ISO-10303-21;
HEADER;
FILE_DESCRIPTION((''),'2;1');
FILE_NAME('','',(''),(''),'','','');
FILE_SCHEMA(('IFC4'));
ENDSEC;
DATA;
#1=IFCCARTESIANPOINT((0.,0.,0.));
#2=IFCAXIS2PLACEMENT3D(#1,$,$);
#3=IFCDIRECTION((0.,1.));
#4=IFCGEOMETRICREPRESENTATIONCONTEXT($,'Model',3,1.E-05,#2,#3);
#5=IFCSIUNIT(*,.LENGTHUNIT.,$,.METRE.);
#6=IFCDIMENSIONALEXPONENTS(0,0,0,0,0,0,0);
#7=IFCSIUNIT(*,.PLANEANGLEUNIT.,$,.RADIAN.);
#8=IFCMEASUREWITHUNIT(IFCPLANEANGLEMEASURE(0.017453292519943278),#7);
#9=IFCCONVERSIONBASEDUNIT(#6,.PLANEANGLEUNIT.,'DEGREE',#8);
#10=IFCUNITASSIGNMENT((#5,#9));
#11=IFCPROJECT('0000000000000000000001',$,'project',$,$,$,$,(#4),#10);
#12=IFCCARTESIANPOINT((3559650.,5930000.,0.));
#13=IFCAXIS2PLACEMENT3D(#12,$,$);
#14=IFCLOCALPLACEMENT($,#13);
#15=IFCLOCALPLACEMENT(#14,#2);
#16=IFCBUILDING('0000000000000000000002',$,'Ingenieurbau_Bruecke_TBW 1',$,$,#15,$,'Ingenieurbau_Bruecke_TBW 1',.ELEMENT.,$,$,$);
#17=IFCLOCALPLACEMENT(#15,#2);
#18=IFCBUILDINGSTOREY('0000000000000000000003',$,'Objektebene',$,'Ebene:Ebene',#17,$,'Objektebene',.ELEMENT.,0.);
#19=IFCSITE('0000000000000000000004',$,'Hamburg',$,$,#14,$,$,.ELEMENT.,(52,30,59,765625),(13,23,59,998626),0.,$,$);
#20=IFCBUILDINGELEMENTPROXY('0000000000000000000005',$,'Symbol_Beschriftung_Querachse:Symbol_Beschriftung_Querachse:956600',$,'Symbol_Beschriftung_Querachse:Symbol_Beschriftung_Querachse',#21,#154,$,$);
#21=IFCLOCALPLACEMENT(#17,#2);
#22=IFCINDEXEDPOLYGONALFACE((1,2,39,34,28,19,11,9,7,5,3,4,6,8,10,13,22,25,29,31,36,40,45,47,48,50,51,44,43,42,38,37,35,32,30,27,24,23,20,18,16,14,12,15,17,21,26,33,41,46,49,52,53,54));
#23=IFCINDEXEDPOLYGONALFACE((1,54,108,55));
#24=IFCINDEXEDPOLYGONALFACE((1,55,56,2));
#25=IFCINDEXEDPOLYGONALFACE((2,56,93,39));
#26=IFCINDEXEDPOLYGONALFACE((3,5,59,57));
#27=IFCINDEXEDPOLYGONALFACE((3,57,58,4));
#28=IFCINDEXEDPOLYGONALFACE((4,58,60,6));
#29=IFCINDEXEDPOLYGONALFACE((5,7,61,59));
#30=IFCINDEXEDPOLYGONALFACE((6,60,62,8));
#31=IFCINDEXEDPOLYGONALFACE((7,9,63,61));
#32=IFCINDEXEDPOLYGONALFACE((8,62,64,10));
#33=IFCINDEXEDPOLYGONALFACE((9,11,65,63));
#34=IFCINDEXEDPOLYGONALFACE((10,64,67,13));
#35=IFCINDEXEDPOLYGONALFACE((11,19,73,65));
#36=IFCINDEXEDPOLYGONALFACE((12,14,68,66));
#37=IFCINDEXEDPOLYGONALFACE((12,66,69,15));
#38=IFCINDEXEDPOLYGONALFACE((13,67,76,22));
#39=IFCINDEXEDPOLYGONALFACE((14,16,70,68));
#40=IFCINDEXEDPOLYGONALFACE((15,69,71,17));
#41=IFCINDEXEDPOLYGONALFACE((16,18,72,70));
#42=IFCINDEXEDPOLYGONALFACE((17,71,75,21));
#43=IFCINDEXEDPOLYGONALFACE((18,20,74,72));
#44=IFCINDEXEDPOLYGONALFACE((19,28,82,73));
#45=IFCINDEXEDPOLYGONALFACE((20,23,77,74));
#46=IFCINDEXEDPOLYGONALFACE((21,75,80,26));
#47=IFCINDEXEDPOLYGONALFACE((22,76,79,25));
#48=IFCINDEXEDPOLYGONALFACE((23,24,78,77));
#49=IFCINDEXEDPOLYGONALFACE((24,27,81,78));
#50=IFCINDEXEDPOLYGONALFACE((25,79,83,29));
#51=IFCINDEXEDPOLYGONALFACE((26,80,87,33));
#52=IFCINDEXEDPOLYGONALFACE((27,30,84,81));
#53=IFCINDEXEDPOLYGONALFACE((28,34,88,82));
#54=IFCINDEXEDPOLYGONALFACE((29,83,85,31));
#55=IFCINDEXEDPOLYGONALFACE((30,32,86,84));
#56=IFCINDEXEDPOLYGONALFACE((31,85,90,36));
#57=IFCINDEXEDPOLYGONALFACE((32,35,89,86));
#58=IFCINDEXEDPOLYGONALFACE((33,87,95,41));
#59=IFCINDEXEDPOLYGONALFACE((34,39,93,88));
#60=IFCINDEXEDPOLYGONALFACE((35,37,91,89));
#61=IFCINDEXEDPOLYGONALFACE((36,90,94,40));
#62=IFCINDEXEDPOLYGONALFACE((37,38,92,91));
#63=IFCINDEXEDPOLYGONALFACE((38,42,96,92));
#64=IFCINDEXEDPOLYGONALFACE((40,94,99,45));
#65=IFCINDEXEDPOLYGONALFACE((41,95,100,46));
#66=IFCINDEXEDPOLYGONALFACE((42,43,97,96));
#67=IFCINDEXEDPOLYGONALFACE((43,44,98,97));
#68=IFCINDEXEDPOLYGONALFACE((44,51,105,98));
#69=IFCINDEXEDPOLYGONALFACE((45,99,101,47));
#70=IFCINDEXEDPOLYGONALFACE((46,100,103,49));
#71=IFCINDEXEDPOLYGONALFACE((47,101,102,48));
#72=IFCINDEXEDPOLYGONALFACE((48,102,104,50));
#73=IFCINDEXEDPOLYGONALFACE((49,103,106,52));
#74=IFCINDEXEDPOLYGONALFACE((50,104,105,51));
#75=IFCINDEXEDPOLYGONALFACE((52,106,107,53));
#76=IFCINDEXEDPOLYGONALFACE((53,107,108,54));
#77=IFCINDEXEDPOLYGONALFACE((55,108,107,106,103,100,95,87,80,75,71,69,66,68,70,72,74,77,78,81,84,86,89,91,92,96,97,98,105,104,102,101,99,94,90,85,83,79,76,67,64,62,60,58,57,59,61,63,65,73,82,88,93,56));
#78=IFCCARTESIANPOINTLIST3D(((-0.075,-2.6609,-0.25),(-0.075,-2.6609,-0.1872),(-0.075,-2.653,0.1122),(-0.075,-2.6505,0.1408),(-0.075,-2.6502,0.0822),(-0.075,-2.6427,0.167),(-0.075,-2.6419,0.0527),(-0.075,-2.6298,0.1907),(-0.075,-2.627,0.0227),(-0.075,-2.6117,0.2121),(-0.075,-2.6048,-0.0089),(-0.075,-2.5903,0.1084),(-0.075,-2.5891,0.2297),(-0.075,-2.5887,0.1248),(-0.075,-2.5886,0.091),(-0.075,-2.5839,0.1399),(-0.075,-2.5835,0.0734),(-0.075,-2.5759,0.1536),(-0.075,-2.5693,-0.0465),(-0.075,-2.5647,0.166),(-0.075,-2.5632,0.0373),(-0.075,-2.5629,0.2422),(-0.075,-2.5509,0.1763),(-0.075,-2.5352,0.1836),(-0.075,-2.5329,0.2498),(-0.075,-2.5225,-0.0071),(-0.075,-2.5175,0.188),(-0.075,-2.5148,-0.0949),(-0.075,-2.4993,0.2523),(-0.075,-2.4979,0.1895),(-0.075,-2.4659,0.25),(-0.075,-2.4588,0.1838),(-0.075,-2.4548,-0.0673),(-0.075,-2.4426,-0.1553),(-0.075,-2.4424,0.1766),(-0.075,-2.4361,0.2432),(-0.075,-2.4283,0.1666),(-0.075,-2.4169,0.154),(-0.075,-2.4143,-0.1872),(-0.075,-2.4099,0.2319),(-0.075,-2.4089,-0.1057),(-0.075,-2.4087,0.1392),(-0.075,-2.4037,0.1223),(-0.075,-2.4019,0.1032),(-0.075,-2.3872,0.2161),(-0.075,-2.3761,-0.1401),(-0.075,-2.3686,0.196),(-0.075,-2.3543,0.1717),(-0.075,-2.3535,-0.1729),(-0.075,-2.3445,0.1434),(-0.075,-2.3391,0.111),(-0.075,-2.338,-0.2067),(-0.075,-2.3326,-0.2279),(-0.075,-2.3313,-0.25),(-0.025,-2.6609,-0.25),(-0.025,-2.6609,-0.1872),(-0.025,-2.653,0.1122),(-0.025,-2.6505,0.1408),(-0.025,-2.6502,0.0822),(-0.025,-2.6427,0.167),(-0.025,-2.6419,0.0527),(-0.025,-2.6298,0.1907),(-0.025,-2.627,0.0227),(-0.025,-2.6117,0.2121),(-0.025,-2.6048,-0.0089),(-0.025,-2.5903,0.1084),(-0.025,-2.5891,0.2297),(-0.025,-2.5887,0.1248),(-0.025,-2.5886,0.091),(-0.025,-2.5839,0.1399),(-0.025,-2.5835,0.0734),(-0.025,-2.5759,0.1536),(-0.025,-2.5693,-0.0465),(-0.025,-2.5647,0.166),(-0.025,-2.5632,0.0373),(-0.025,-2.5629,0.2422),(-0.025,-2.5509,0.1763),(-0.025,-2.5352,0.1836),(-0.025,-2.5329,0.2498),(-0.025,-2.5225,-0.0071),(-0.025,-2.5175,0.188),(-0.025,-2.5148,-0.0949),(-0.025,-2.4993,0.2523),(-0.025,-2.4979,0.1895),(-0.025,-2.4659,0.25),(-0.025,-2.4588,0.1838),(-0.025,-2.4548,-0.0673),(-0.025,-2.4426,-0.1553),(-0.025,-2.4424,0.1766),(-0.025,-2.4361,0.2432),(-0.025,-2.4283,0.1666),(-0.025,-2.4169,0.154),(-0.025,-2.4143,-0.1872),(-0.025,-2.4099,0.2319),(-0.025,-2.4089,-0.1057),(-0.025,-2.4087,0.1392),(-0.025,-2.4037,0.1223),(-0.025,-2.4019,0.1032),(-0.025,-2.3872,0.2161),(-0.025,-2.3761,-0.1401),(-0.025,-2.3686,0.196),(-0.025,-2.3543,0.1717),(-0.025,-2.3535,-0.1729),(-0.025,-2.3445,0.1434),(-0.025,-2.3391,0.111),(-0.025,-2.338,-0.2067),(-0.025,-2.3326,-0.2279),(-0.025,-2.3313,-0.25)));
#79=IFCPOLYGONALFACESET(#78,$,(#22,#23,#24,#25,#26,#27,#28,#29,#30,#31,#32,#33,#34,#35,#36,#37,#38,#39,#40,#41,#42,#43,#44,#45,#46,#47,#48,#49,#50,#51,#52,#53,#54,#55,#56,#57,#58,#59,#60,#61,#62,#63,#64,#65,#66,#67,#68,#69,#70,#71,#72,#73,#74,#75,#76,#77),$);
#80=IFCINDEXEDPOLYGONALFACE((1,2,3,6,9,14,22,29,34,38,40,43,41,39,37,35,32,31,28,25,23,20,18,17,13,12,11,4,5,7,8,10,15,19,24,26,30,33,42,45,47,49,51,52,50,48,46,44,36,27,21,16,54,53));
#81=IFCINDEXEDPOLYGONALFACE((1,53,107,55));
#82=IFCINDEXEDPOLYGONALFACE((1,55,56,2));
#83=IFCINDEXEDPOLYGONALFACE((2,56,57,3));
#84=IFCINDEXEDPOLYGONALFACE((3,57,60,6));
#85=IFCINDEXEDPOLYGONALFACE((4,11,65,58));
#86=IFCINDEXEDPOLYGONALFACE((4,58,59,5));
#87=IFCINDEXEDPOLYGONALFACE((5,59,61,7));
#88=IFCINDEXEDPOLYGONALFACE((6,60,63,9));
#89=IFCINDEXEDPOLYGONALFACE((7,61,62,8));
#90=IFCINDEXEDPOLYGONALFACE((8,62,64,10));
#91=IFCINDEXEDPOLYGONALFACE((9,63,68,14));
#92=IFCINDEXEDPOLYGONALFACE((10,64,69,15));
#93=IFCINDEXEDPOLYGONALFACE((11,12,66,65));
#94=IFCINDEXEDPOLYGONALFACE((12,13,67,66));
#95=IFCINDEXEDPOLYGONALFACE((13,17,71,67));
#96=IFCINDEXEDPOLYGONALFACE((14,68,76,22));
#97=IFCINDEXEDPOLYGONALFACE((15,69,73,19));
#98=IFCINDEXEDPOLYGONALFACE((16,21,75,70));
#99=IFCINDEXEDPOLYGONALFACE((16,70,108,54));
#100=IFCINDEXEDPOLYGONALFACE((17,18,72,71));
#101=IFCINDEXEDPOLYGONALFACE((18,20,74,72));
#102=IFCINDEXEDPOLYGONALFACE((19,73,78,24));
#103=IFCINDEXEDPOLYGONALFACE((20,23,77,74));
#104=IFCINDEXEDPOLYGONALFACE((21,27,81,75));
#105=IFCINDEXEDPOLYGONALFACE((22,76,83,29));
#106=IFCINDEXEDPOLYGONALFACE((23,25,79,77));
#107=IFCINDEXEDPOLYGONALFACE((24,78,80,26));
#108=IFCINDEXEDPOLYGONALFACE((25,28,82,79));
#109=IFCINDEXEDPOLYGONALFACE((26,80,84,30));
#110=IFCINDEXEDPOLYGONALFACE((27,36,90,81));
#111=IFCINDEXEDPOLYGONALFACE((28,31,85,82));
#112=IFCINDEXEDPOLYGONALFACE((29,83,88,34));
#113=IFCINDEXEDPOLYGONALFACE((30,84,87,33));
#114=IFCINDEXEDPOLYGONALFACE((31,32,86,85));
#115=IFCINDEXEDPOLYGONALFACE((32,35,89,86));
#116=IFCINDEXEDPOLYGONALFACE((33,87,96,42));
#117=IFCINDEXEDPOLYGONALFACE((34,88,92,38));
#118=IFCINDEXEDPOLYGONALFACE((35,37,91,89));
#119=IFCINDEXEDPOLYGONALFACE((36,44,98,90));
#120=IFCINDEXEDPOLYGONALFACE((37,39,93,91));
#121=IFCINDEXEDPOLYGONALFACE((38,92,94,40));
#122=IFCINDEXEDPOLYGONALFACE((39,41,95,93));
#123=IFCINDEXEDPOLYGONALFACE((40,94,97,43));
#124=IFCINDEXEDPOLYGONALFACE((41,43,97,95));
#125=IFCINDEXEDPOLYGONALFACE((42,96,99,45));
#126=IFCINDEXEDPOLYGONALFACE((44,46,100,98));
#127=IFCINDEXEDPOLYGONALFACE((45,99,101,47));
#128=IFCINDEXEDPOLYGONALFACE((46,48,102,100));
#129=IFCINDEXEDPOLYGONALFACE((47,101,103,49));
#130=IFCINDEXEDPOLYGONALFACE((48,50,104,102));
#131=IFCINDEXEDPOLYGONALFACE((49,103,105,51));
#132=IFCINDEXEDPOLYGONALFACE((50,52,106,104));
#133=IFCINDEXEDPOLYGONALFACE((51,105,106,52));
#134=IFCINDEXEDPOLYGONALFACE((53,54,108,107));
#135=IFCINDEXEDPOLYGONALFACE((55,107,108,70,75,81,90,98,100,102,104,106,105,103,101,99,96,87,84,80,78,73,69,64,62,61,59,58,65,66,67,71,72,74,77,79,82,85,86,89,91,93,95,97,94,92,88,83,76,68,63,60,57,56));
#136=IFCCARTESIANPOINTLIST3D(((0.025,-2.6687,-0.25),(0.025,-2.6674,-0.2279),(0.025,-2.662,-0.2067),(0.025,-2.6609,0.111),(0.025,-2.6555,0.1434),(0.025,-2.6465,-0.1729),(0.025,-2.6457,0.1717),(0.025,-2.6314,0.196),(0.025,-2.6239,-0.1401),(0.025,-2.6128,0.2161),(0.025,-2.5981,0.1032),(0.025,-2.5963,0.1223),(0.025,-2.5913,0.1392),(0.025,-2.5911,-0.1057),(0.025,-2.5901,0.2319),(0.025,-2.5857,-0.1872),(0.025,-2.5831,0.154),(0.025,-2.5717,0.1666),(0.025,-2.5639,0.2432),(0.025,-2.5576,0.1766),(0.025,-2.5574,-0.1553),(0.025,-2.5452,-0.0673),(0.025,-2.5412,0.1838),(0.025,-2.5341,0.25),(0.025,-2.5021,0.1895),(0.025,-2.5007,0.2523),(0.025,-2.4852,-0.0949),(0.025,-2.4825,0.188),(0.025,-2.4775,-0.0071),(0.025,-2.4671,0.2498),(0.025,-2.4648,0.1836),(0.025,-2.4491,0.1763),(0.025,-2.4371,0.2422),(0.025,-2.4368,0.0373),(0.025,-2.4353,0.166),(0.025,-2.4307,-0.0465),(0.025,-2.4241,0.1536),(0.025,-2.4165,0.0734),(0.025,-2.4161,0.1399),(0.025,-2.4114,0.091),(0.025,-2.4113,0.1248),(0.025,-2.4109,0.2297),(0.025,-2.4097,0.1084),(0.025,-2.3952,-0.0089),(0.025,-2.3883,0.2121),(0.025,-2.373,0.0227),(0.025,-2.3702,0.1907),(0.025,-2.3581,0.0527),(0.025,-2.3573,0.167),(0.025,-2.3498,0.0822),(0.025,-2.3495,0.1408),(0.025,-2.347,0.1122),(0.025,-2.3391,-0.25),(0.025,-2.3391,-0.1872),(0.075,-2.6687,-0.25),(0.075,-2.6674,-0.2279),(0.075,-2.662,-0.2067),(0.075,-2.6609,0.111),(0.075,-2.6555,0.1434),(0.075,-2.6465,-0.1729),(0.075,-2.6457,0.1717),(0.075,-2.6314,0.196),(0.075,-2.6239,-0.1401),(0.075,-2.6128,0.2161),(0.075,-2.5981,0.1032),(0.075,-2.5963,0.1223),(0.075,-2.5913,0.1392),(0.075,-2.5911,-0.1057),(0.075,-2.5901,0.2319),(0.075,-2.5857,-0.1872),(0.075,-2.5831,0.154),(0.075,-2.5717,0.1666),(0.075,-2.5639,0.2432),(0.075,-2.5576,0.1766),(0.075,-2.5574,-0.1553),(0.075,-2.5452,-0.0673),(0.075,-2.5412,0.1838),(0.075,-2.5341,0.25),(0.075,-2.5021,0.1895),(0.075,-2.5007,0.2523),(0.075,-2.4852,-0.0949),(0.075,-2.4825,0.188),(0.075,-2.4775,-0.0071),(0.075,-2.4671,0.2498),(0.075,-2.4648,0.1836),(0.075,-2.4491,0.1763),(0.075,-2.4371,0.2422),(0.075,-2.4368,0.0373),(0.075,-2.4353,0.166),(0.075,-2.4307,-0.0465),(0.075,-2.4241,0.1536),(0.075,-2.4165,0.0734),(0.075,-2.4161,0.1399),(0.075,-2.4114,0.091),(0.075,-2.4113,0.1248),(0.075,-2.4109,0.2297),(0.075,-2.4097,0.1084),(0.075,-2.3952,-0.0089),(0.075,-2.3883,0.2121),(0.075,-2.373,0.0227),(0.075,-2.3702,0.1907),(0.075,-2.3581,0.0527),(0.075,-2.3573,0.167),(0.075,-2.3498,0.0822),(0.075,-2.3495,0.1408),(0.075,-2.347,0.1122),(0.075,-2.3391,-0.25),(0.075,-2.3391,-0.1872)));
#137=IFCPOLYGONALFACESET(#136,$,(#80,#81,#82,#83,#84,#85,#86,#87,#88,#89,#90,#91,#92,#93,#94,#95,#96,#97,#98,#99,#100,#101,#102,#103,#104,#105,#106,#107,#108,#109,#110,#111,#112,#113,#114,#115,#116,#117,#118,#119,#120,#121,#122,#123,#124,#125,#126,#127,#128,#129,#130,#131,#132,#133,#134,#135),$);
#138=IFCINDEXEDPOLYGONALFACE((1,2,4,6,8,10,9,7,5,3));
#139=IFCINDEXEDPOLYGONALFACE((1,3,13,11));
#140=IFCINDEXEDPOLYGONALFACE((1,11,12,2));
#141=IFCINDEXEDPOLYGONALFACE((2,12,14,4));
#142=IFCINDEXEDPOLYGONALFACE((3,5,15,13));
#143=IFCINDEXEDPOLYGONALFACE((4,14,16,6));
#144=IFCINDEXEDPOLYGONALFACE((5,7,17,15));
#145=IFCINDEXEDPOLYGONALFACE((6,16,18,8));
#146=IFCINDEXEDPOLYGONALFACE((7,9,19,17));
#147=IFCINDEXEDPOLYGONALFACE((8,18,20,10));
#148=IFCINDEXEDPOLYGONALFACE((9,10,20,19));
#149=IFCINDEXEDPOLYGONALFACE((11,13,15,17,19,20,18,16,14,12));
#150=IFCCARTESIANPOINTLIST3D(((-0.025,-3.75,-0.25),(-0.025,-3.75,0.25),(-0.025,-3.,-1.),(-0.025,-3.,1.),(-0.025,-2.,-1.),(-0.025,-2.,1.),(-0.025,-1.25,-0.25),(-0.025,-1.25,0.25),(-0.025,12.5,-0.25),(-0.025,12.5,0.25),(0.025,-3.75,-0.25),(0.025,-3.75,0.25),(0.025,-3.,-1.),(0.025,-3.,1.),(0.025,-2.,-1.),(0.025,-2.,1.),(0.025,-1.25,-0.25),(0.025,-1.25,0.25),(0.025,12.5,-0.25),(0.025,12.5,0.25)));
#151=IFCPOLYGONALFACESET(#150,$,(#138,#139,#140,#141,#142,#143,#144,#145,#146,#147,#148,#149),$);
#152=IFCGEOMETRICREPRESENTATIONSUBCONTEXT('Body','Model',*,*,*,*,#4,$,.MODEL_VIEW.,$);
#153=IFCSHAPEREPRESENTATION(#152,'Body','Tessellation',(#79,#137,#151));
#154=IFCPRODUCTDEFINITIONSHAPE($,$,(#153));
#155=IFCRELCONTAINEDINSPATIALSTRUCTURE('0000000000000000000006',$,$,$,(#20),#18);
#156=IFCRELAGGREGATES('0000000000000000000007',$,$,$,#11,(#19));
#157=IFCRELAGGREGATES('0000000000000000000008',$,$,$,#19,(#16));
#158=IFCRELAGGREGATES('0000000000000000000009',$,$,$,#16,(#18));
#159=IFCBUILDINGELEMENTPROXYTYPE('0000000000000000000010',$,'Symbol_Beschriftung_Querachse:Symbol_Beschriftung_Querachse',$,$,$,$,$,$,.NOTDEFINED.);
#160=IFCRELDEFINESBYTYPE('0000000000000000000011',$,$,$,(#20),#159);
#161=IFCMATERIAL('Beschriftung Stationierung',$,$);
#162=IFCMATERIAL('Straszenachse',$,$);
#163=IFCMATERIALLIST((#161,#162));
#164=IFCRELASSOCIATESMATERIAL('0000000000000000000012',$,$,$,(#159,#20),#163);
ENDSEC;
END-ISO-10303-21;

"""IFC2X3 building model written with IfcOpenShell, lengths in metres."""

from ifc_helpers import new_model, entity, si_unit, converted_unit, direction, frame, origin, place, context, subcontext, project, spatial, polyline, outline, extrude, source, transform, mapped, material, material_list, type_object, type_shapes, element, save


model = new_model("IFC2X3")

# Units and contexts
model_context = context("Model", 3, precision=1e-05, world=origin(), true_north=direction((0.0, 1.0)))
body_context = subcontext(model_context, "Body", "Model", "MODEL_VIEW")
ifc_project = project(units=[si_unit("LENGTHUNIT", "METRE"), converted_unit("PLANEANGLEUNIT", "DEGREE", entity("IfcPlaneAngleMeasure", 0.017453292519943278), si_unit("PLANEANGLEUNIT", "RADIAN"), dimensions=[0, 0, 0, 0, 0, 0, 0])], contexts=[model_context])

# Site, building, storey
site_placement = place(None, frame((3559650.0, 5930000.0, 0.0)))
site = spatial("IfcSite", under=ifc_project, at=site_placement, Name="Hamburg", CompositionType="ELEMENT", RefLatitude=(52, 30, 59, 765625), RefLongitude=(13, 23, 59, 998626), RefElevation=0.0)
building_placement = place(site_placement, origin())
building = spatial("IfcBuilding", under=site, at=building_placement, Name="Ingenieurbau_Bruecke_TBW 1", LongName="Ingenieurbau_Bruecke_TBW 1", CompositionType="ELEMENT")
storey_placement = place(building_placement, origin())
storey = spatial("IfcBuildingStorey", under=building, at=storey_placement, Name="Objektebene", ObjectType="Ebene:Ebene", LongName="Objektebene", CompositionType="ELEMENT", Elevation=0.0)

# Shared definitions
ifc_material_1 = material(Name="Beschriftung Stationierung")
ifc_material_2 = material(Name="Straszenachse")
ifc_material_list_1 = material_list([ifc_material_1, ifc_material_2])

# Building element proxy
building_element_proxy_type_1 = type_object("IfcBuildingElementProxyType", Name="Symbol_Beschriftung_Querachse:Symbol_Beschriftung_Querachse", PredefinedType="NOTDEFINED", material=ifc_material_list_1)
shared_shape_1 = source(origin(), body_context, "Body", "SweptSolid", [
    extrude(outline(polyline([(-0.1594, -0.2629), (-0.1594, -0.3257), (0.1703, -0.3257), (0.1689, -0.3036), (0.1635, -0.2824), (0.148, -0.2486), (0.1254, -0.2158), (0.0926, -0.1814), (0.0468, -0.143), (-0.021, -0.0828), (-0.0616, -0.0384), (-0.0819, -0.0023), (-0.087, 0.0153), (-0.0887, 0.0327), (-0.0871, 0.0491), (-0.0823, 0.0642), (-0.0743, 0.0779), (-0.0632, 0.0903), (-0.0494, 0.1006), (-0.0337, 0.1079), (-0.016, 0.1123), (0.0036, 0.1138), (0.0428, 0.1081), (0.0591, 0.1009), (0.0732, 0.0909), (0.0846, 0.0783), (0.0928, 0.0635), (0.0978, 0.0466), (0.0996, 0.0275), (0.1624, 0.0353), (0.157, 0.0677), (0.1472, 0.096), (0.133, 0.1203), (0.1143, 0.1404), (0.0916, 0.1562), (0.0654, 0.1675), (0.0356, 0.1743), (0.0023, 0.1766), (-0.0314, 0.1741), (-0.0613, 0.1665), (-0.0876, 0.154), (-0.1101, 0.1364), (-0.1282, 0.115), (-0.1412, 0.0913), (-0.1489, 0.0651), (-0.1515, 0.0365), (-0.1487, 0.0065), (-0.1403, -0.023), (-0.1255, -0.053), (-0.1033, -0.0846), (-0.0678, -0.1222), (-0.0133, -0.1706), (0.0589, -0.231), (0.0872, -0.2629), (-0.1594, -0.2629)])), frame((-15.0015, 0.025, 0.0757), z_axis=(0.0, -1.0, 0.0), x_axis=(1.0, 0.0, 0.0)), (0.0, 0.0, -1.0), 0.05),
    extrude(outline(polyline([(0.2629, -0.1594), (0.3257, -0.1594), (0.3257, 0.1703), (0.3036, 0.1689), (0.2824, 0.1635), (0.2486, 0.148), (0.2158, 0.1254), (0.1814, 0.0926), (0.143, 0.0468), (0.0828, -0.021), (0.0384, -0.0616), (0.0023, -0.0819), (-0.0153, -0.087), (-0.0327, -0.0887), (-0.0491, -0.0871), (-0.0642, -0.0823), (-0.0779, -0.0743), (-0.0903, -0.0632), (-0.1006, -0.0494), (-0.1079, -0.0337), (-0.1123, -0.016), (-0.1138, 0.0036), (-0.1081, 0.0428), (-0.1009, 0.0591), (-0.0909, 0.0732), (-0.0783, 0.0846), (-0.0635, 0.0928), (-0.0466, 0.0978), (-0.0275, 0.0996), (-0.0353, 0.1624), (-0.0677, 0.157), (-0.096, 0.1472), (-0.1203, 0.133), (-0.1404, 0.1143), (-0.1562, 0.0916), (-0.1675, 0.0654), (-0.1743, 0.0356), (-0.1766, 0.0023), (-0.1741, -0.0314), (-0.1665, -0.0613), (-0.154, -0.0876), (-0.1364, -0.1101), (-0.115, -0.1282), (-0.0913, -0.1412), (-0.0651, -0.1489), (-0.0365, -0.1515), (-0.0065, -0.1487), (0.023, -0.1403), (0.053, -0.1255), (0.0846, -0.1033), (0.1222, -0.0678), (0.1706, -0.0133), (0.231, 0.0589), (0.2629, 0.0872), (0.2629, -0.1594)])), frame((-14.9985, -0.075, 0.0757), z_axis=(0.0, 1.0, 0.0), x_axis=(0.0, 0.0, -1.0)), (0.0, 0.0, 1.0), 0.05),
    extrude(outline(polyline([(-12.0, 0.25), (-12.0, -0.25), (1.75, -0.25), (2.5, -1.0), (3.5, -1.0), (4.25, -0.25), (4.25, 0.25), (3.5, 1.0), (2.5, 1.0), (1.75, 0.25), (-12.0, 0.25)])), frame((-12.0, -0.025, 0.0), z_axis=(0.0, -1.0, 0.0), x_axis=(-1.0, 0.0, 0.0)), (0.0, 0.0, -1.0), 0.05),
])
type_shapes(building_element_proxy_type_1, [shared_shape_1])
proxy_1_placement = place(storey_placement, frame((0.0, 12.5, 0.0), z_axis=(0.0, 0.0, 1.0), x_axis=(0.0, 1.0, 0.0)))
element("IfcBuildingElementProxy", 1, at=proxy_1_placement, inside=storey, type_object=building_element_proxy_type_1, material=ifc_material_list_1, Name="Symbol_Beschriftung_Querachse:Symbol_Beschriftung_Querachse:956600", ObjectType="Symbol_Beschriftung_Querachse:Symbol_Beschriftung_Querachse", context=body_context, shape_type="MappedRepresentation", body=[
    mapped(shared_shape_1, transform((0.0, 0.0, 0.0), scale=1.0)),
])

save(model, "model.ifc")
